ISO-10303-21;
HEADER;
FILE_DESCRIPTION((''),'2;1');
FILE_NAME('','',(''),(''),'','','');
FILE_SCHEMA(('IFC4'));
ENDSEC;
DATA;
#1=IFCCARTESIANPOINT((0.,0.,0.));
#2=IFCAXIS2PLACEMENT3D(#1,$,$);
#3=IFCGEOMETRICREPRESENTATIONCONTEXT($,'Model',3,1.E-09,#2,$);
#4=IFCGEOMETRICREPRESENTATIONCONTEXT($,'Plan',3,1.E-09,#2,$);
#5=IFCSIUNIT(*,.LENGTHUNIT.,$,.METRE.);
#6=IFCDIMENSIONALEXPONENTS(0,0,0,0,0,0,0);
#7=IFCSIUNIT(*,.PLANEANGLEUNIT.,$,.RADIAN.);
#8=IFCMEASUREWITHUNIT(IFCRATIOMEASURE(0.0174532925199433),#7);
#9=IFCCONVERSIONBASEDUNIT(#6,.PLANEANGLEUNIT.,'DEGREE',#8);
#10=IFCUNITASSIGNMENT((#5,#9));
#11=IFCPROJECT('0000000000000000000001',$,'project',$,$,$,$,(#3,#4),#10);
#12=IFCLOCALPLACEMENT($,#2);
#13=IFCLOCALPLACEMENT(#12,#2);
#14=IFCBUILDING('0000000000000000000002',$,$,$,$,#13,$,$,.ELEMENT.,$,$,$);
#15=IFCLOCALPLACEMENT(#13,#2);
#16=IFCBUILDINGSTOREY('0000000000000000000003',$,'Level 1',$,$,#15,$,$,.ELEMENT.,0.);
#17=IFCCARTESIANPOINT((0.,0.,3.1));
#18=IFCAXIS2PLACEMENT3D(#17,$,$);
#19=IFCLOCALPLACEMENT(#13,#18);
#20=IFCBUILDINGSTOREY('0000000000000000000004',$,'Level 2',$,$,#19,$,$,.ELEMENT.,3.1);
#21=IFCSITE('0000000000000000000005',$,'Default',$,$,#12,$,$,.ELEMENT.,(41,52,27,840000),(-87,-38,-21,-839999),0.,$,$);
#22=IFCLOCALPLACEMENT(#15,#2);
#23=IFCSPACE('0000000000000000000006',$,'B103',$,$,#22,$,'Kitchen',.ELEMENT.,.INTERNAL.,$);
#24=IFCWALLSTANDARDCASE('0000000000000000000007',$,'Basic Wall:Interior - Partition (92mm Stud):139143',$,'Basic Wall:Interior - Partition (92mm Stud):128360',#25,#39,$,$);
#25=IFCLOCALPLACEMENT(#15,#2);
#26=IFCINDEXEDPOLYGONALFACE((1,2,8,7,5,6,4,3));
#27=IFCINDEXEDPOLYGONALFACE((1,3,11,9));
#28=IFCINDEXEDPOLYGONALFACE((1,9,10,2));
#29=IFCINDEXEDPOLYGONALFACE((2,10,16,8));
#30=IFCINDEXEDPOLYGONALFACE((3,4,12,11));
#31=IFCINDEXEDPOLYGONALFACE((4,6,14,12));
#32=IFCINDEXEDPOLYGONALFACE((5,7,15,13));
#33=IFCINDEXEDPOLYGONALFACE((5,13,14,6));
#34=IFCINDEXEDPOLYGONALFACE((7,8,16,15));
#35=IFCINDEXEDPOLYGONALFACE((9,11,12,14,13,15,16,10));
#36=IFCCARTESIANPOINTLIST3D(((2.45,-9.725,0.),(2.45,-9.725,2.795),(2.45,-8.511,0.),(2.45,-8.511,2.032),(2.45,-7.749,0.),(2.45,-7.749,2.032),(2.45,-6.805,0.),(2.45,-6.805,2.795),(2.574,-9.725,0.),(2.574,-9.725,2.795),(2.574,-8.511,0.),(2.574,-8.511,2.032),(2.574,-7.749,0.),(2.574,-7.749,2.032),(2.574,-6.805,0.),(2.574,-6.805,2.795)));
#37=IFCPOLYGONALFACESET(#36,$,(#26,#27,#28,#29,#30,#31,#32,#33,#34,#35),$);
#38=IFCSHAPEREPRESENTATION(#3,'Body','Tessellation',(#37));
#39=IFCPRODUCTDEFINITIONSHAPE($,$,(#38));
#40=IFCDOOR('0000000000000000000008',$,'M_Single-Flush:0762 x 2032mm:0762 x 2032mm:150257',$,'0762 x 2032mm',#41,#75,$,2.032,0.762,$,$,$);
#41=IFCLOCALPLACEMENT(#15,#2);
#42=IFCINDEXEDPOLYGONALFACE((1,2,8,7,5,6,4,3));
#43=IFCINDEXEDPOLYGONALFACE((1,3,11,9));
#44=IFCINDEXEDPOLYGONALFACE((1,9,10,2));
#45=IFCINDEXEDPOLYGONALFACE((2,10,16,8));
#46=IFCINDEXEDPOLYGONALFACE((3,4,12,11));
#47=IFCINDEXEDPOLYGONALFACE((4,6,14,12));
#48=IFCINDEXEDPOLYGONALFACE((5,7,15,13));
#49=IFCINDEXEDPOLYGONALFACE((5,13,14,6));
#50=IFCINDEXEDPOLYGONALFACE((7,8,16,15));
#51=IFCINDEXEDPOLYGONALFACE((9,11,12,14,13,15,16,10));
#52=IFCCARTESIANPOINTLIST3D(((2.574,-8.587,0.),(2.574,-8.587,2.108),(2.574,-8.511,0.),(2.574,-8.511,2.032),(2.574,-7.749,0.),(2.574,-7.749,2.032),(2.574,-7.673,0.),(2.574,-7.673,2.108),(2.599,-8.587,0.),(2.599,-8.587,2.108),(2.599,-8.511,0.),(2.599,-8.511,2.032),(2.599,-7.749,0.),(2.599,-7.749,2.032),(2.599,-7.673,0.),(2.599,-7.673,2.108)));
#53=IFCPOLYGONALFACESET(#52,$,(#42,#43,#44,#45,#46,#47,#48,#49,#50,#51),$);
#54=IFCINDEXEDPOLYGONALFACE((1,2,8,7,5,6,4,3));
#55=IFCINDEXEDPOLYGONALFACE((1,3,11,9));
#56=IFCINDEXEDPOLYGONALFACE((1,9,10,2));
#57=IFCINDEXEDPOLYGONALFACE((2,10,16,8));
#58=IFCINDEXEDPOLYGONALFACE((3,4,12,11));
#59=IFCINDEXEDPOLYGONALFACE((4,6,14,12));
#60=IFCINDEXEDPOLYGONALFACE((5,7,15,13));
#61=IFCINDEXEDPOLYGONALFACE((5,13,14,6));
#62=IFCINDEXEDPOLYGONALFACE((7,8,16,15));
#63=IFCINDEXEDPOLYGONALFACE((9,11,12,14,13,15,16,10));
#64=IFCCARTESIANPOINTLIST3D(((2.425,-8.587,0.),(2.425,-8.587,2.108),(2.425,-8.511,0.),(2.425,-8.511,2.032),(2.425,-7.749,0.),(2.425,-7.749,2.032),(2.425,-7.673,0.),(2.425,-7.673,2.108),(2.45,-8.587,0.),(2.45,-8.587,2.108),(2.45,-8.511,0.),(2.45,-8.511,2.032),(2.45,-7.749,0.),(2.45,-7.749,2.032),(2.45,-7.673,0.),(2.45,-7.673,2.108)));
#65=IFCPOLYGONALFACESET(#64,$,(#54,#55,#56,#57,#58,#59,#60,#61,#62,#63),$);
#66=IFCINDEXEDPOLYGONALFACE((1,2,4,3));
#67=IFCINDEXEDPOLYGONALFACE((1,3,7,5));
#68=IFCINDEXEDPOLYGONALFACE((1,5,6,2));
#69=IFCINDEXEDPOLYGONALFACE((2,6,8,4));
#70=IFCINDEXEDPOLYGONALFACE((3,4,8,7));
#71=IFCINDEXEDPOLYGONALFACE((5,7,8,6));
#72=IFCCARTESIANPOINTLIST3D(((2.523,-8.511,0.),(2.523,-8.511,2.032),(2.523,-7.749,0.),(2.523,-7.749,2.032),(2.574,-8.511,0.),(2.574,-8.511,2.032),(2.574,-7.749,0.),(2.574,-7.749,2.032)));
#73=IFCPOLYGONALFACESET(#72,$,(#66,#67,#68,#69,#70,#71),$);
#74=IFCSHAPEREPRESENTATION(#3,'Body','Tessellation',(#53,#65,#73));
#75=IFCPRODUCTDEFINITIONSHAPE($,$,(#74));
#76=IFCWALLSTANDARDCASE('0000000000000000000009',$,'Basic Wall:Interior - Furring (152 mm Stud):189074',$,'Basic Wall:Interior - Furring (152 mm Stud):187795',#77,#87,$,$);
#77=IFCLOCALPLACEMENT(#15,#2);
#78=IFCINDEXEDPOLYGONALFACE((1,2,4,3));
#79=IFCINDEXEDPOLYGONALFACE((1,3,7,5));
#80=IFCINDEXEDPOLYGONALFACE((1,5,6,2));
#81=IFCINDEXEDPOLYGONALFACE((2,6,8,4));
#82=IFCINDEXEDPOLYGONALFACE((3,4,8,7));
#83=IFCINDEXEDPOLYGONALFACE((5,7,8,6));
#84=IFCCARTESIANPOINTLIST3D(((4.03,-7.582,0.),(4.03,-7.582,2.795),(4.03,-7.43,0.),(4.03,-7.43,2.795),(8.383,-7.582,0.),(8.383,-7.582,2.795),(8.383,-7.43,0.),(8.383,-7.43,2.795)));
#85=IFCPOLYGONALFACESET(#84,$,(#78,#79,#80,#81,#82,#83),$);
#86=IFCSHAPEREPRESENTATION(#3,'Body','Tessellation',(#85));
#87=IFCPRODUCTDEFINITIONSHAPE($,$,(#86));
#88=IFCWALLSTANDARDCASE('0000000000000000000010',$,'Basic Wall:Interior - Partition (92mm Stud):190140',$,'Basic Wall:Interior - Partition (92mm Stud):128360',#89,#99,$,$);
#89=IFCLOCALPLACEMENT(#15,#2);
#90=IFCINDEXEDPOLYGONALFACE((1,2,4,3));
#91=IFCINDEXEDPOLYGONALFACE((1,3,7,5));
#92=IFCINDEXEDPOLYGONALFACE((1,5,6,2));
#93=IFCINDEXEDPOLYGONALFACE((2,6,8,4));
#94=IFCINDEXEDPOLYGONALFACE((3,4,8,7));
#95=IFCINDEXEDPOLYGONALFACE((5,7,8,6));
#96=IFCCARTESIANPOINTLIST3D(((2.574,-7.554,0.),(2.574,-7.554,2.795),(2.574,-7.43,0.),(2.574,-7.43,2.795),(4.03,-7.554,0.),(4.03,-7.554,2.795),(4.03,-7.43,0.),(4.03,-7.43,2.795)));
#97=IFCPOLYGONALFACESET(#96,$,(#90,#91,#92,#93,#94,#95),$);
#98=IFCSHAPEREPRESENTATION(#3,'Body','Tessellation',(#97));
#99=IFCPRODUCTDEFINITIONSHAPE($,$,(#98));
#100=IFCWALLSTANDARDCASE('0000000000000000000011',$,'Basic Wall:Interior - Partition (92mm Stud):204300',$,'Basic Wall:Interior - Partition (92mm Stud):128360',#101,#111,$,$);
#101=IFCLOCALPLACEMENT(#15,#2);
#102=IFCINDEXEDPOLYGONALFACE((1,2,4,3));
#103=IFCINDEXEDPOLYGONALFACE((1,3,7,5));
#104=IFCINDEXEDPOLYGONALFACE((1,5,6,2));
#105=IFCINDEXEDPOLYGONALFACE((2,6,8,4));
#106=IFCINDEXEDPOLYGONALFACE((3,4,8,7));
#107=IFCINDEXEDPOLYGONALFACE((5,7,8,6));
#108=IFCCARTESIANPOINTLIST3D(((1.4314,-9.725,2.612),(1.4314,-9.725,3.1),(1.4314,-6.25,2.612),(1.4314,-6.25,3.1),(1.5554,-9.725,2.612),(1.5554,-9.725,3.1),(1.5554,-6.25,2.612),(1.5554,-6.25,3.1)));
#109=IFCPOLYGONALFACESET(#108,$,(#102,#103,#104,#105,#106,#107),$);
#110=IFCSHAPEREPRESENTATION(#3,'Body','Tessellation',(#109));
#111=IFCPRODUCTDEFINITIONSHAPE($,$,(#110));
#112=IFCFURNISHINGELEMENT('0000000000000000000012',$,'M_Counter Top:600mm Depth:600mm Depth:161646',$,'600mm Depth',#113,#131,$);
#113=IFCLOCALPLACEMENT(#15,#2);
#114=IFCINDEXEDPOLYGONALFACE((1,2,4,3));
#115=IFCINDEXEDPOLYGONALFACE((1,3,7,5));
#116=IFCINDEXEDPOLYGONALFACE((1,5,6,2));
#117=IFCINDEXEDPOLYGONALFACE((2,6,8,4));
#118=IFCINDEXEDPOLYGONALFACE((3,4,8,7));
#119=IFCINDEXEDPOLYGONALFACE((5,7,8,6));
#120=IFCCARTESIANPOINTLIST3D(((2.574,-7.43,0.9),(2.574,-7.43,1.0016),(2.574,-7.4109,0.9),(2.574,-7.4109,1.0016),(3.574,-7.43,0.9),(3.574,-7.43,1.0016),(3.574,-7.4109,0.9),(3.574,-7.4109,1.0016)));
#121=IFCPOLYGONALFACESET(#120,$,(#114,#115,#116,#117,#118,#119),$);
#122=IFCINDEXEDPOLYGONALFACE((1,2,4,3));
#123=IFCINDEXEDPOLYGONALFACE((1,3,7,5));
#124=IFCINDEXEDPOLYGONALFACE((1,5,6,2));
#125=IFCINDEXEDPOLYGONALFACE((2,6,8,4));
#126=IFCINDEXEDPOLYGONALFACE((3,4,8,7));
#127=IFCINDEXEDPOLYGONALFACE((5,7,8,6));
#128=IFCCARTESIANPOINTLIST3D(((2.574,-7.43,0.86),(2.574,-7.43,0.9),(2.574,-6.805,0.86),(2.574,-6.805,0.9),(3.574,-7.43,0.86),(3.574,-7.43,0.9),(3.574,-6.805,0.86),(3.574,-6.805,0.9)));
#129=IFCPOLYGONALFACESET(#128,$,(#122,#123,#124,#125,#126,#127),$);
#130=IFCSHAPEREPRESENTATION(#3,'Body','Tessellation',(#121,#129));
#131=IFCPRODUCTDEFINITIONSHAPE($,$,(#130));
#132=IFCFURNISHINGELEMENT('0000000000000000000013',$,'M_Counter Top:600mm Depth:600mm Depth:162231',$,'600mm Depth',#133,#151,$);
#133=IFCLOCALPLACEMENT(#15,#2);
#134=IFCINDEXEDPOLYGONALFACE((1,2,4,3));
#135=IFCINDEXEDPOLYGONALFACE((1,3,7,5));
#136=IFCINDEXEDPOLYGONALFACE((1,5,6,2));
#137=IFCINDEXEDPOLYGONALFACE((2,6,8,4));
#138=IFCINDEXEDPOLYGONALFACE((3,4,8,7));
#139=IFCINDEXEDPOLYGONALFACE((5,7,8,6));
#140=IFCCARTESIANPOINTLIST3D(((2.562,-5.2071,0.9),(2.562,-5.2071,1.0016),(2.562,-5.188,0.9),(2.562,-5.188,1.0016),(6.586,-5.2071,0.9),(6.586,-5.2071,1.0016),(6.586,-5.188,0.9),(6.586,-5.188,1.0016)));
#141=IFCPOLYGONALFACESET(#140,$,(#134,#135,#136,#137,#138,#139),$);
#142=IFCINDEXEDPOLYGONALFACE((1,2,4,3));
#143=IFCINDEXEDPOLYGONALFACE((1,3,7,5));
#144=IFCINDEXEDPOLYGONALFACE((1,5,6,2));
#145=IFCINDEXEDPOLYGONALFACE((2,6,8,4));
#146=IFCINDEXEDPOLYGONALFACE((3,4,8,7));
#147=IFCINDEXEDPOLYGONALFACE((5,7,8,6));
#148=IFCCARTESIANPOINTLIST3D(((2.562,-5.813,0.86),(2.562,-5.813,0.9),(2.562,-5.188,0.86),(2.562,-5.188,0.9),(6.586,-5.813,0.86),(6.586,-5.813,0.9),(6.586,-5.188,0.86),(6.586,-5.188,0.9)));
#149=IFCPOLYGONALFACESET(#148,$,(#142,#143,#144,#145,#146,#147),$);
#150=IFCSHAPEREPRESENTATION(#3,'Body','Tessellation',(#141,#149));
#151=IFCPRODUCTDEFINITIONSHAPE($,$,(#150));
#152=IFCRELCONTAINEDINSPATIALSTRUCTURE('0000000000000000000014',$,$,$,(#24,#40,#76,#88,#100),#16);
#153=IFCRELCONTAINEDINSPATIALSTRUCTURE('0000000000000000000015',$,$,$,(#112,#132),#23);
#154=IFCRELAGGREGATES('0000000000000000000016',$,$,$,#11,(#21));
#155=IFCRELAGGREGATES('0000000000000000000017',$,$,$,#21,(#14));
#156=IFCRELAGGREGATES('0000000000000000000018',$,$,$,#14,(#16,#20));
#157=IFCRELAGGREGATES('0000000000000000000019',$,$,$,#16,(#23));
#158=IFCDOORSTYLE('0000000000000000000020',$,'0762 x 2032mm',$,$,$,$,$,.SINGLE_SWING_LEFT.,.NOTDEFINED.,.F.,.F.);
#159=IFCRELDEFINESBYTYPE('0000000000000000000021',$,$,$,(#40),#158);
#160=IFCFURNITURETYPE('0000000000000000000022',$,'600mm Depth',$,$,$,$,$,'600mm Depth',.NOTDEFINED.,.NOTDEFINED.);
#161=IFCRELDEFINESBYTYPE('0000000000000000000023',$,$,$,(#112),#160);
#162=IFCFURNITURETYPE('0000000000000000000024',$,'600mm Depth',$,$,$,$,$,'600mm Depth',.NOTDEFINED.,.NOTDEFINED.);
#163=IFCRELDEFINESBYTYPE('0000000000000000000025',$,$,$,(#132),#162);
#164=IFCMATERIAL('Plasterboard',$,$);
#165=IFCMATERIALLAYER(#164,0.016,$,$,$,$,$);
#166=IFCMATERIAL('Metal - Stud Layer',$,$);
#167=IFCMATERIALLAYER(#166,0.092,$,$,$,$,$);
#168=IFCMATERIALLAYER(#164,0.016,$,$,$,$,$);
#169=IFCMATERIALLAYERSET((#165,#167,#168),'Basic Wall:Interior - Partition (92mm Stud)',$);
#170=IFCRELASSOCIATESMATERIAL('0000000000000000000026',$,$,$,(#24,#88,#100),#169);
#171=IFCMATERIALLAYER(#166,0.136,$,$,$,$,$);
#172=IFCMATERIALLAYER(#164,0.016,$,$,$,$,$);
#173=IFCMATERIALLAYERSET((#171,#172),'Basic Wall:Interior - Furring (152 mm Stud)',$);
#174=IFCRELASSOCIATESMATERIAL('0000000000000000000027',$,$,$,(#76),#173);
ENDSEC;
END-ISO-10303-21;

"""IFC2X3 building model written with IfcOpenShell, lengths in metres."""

from ifc_helpers import new_model, entity, si_unit, converted_unit, frame, frame_2d, origin, origin_2d_with_axis, place, context, project, spatial, polyline, rectangle, outline, extrude, clip, bounded_halfspace, source, transform, mapped, material, layer, layer_set, layer_usage, type_object, type_shapes, element, fill, save


model = new_model("IFC2X3")

# Units and contexts
model_context = context("Model", 3, precision=1e-09, world=origin())
plan_context = context("Plan", 3, precision=1e-09, world=origin())
ifc_project = project(units=[si_unit("LENGTHUNIT", "METRE"), converted_unit("PLANEANGLEUNIT", "DEGREE", entity("IfcRatioMeasure", 0.0174532925199433), si_unit("PLANEANGLEUNIT", "RADIAN"), dimensions=[0, 0, 0, 0, 0, 0, 0])], contexts=[model_context, plan_context])

# Site, building, storey
site_placement = place(None, origin())
site = spatial("IfcSite", under=ifc_project, at=site_placement, Name="Default", CompositionType="ELEMENT", RefLatitude=(41, 52, 27, 840000), RefLongitude=(-87, -38, -21, -839999), RefElevation=0.0)
building_placement = place(site_placement, origin())
building = spatial("IfcBuilding", under=site, at=building_placement, CompositionType="ELEMENT")
storey_1_placement = place(building_placement, origin())
storey_1 = spatial("IfcBuildingStorey", under=building, at=storey_1_placement, Name="Level 1", CompositionType="ELEMENT", Elevation=0.0)

# Shared definitions
ifc_material_1 = material(Name="Metal - Stud Layer")
ifc_material_2 = material(Name="Plasterboard")

# Shared definitions
ifc_layer_1 = layer(ifc_material_2, 0.016)
ifc_layer_2 = layer(ifc_material_1, 0.092)
ifc_layer_3 = layer(ifc_material_2, 0.016)
ifc_layer_set_1 = layer_set([ifc_layer_1, ifc_layer_2, ifc_layer_3], Name="Basic Wall:Interior - Partition (92mm Stud)")

# Wall, opening, door
ifc_layer_usage_1 = layer_usage(ifc_layer_set_1, "AXIS2", "NEGATIVE", 0.062)
wall_1_placement = place(storey_1_placement, frame((2.512, -6.805, 0.0), z_axis=(0.0, 0.0, 1.0), x_axis=(0.0, -1.0, 0.0)))
wall_1 = element("IfcWallStandardCase", 1, at=wall_1_placement, inside=storey_1, material=ifc_layer_usage_1, Name="Basic Wall:Interior - Partition (92mm Stud):139143", ObjectType="Basic Wall:Interior - Partition (92mm Stud):128360", context=model_context, shape_type="SweptSolid", body=[
    extrude(rectangle(XDim=2.92, YDim=0.124, at=frame_2d((1.46, 0.0), x_axis=(-1.0, 0.0))), origin(), (0.0, 0.0, 1.0), 2.795),
])
opening_1_placement = place(wall_1_placement, frame((0.944, -0.062, 0.0)))
opening_1 = element("IfcOpeningElement", 2, at=opening_1_placement, cuts=wall_1, ObjectType="Opening", context=model_context, shape_type="SweptSolid", body=[
    extrude(rectangle(XDim=0.762, YDim=2.032, at=frame_2d((1.016, 0.381), x_axis=(0.0, -1.0))), frame((0.0, 0.0, 0.0), z_axis=(0.0, 1.0, 0.0), x_axis=(0.0, 0.0, 1.0)), (0.0, 0.0, 1.0), 0.124),
])
door_style_1 = type_object("IfcDoorStyle", Name="0762 x 2032mm", ConstructionType="NOTDEFINED", OperationType="SINGLE_SWING_LEFT", ParameterTakesPrecedence=False, Sizeable=False)
shared_shape_1 = source(origin(), model_context, "Body", "SweptSolid", [
    extrude(outline(polyline([(-0.457, -1.073), (0.457, -1.073), (0.457, 1.035), (0.381, 1.035), (0.381, -0.997), (-0.381, -0.997), (-0.381, 1.035), (-0.457, 1.035), (-0.457, -1.073)])), frame((0.381, 0.149, 1.035), z_axis=(0.0, -1.0, 0.0), x_axis=(-1.0, 0.0, 0.0)), (0.0, 0.0, 1.0), 0.025),
    extrude(outline(polyline([(-1.073, -0.457), (1.035, -0.457), (1.035, -0.381), (-0.997, -0.381), (-0.997, 0.381), (1.035, 0.381), (1.035, 0.457), (-1.073, 0.457), (-1.073, -0.457)])), frame((0.381, 0.0, 1.035), z_axis=(0.0, -1.0, 0.0), x_axis=(0.0, 0.0, -1.0)), (0.0, 0.0, 1.0), 0.025),
    extrude(rectangle(XDim=0.762, YDim=0.051, at=origin_2d_with_axis()), frame((0.381, 0.0985, 0.0)), (0.0, 0.0, 1.0), 2.032),
])
type_shapes(door_style_1, [shared_shape_1])
door_1_placement = place(opening_1_placement, origin())
door_1 = element("IfcDoor", 3, at=door_1_placement, inside=storey_1, type_object=door_style_1, Name="M_Single-Flush:0762 x 2032mm:0762 x 2032mm:150257", ObjectType="0762 x 2032mm", OverallHeight=2.032, OverallWidth=0.762, context=model_context, shape_type="MappedRepresentation", body=[
    mapped(shared_shape_1, transform((0.0, 0.0, 0.0), scale=1.0)),
])
fill(opening_1, door_1)

# Shared definitions
storey_2_placement = place(building_placement, frame((0.0, 0.0, 3.1)))
storey_2 = spatial("IfcBuildingStorey", under=building, at=storey_2_placement, Name="Level 2", CompositionType="ELEMENT", Elevation=3.1)

# Walls
ifc_layer_4 = layer(ifc_material_1, 0.136)
ifc_layer_5 = layer(ifc_material_2, 0.016)
ifc_layer_set_2 = layer_set([ifc_layer_4, ifc_layer_5], Name="Basic Wall:Interior - Furring (152 mm Stud)")
ifc_layer_usage_2 = layer_usage(ifc_layer_set_2, "AXIS2", "NEGATIVE", 0.076)
wall_2_placement = place(storey_1_placement, frame((8.383, -7.506, 0.0), z_axis=(0.0, 0.0, 1.0), x_axis=(-1.0, 0.0, 0.0)))
element("IfcWallStandardCase", 4, at=wall_2_placement, inside=storey_1, material=ifc_layer_usage_2, Name="Basic Wall:Interior - Furring (152 mm Stud):189074", ObjectType="Basic Wall:Interior - Furring (152 mm Stud):187795", context=model_context, shape_type="Clipping", body=[
    clip(extrude(rectangle(XDim=4.353, YDim=0.152, at=frame_2d((2.1765, 0.0), x_axis=(-1.0, 0.0))), origin(), (0.0, 0.0, 1.0), 2.795), bounded_halfspace(frame((0.0, -0.076, 2.795), z_axis=(0.0, 0.0, -1.0), x_axis=(0.0, 1.0, 0.0)), True, frame((0.0, -0.076, 2.795)), polyline([(0.0, 0.0), (3.708, 0.0), (3.708, 0.152), (0.0, 0.152), (0.0, 0.0)]))),
])
ifc_layer_usage_3 = layer_usage(ifc_layer_set_1, "AXIS2", "NEGATIVE", 0.062)
wall_3_placement = place(storey_1_placement, frame((4.03, -7.492, 0.0), z_axis=(0.0, 0.0, 1.0), x_axis=(-1.0, 0.0, 0.0)))
element("IfcWallStandardCase", 5, at=wall_3_placement, inside=storey_1, material=ifc_layer_usage_3, Name="Basic Wall:Interior - Partition (92mm Stud):190140", ObjectType="Basic Wall:Interior - Partition (92mm Stud):128360", context=model_context, shape_type="SweptSolid", body=[
    extrude(rectangle(XDim=1.456, YDim=0.124, at=frame_2d((0.728, 0.0), x_axis=(-1.0, 0.0))), origin(), (0.0, 0.0, 1.0), 2.795),
])
ifc_layer_usage_4 = layer_usage(ifc_layer_set_1, "AXIS2", "NEGATIVE", 0.062)
wall_4_placement = place(storey_1_placement, frame((1.4934, -6.25, 2.612), z_axis=(0.0, 0.0, 1.0), x_axis=(0.0, -1.0, 0.0)))
element("IfcWallStandardCase", 6, at=wall_4_placement, inside=storey_1, material=ifc_layer_usage_4, Name="Basic Wall:Interior - Partition (92mm Stud):204300", ObjectType="Basic Wall:Interior - Partition (92mm Stud):128360", context=model_context, shape_type="SweptSolid", body=[
    extrude(rectangle(XDim=3.475, YDim=0.124, at=frame_2d((1.7375, 0.0), x_axis=(-1.0, 0.0))), origin(), (0.0, 0.0, 1.0), 0.488),
])

# Shared definitions
space_1_placement = place(storey_1_placement, origin())
space_1 = spatial("IfcSpace", under=storey_1, at=space_1_placement, Name="B103", LongName="Kitchen", CompositionType="ELEMENT", InteriorOrExteriorSpace="INTERNAL")

# Furnishing elements
furniture_type_1 = type_object("IfcFurnitureType", Name="600mm Depth", ElementType="600mm Depth", AssemblyPlace="NOTDEFINED")
shared_shape_2 = source(origin(), model_context, "Body", "SweptSolid", [
    extrude(rectangle(XDim=0.0191, YDim=1.0, at=origin_2d_with_axis()), frame((-0.7005, -0.0095, 0.9), z_axis=(0.0, 0.0, 1.0), x_axis=(0.0, -1.0, 0.0)), (0.0, 0.0, 1.0), 0.1016),
    extrude(rectangle(XDim=1.0, YDim=0.625, at=origin_2d_with_axis()), frame((-0.7005, -0.3125, 0.86), z_axis=(0.0, 0.0, 1.0), x_axis=(-1.0, 0.0, 0.0)), (0.0, 0.0, 1.0), 0.04),
])
type_shapes(furniture_type_1, [shared_shape_2])
furnishing_1_placement = place(space_1_placement, frame((2.3735, -7.43, 0.0), z_axis=(0.0, 0.0, 1.0), x_axis=(-1.0, 0.0, 0.0)))
element("IfcFurnishingElement", 7, at=furnishing_1_placement, inside=space_1, type_object=furniture_type_1, Name="M_Counter Top:600mm Depth:600mm Depth:161646", ObjectType="600mm Depth", context=model_context, shape_type="MappedRepresentation", body=[
    mapped(shared_shape_2, transform((0.0, 0.0, 0.0), scale=1.0)),
])
furniture_type_2 = type_object("IfcFurnitureType", Name="600mm Depth", ElementType="600mm Depth", AssemblyPlace="NOTDEFINED")
shared_shape_3 = source(origin(), model_context, "Body", "SweptSolid", [
    extrude(rectangle(XDim=0.0191, YDim=4.024, at=origin_2d_with_axis()), frame((0.8115, -0.0095, 0.9), z_axis=(0.0, 0.0, 1.0), x_axis=(0.0, -1.0, 0.0)), (0.0, 0.0, 1.0), 0.1016),
    extrude(rectangle(XDim=4.024, YDim=0.625, at=origin_2d_with_axis()), frame((0.8115, -0.3125, 0.86), z_axis=(0.0, 0.0, 1.0), x_axis=(-1.0, 0.0, 0.0)), (0.0, 0.0, 1.0), 0.04),
])
type_shapes(furniture_type_2, [shared_shape_3])
furnishing_2_placement = place(space_1_placement, frame((3.7625, -5.188, 0.0)))
element("IfcFurnishingElement", 8, at=furnishing_2_placement, inside=space_1, type_object=furniture_type_2, Name="M_Counter Top:600mm Depth:600mm Depth:162231", ObjectType="600mm Depth", context=model_context, shape_type="MappedRepresentation", body=[
    mapped(shared_shape_3, transform((0.0, 0.0, 0.0), scale=1.0)),
])

save(model, "model.ifc")
